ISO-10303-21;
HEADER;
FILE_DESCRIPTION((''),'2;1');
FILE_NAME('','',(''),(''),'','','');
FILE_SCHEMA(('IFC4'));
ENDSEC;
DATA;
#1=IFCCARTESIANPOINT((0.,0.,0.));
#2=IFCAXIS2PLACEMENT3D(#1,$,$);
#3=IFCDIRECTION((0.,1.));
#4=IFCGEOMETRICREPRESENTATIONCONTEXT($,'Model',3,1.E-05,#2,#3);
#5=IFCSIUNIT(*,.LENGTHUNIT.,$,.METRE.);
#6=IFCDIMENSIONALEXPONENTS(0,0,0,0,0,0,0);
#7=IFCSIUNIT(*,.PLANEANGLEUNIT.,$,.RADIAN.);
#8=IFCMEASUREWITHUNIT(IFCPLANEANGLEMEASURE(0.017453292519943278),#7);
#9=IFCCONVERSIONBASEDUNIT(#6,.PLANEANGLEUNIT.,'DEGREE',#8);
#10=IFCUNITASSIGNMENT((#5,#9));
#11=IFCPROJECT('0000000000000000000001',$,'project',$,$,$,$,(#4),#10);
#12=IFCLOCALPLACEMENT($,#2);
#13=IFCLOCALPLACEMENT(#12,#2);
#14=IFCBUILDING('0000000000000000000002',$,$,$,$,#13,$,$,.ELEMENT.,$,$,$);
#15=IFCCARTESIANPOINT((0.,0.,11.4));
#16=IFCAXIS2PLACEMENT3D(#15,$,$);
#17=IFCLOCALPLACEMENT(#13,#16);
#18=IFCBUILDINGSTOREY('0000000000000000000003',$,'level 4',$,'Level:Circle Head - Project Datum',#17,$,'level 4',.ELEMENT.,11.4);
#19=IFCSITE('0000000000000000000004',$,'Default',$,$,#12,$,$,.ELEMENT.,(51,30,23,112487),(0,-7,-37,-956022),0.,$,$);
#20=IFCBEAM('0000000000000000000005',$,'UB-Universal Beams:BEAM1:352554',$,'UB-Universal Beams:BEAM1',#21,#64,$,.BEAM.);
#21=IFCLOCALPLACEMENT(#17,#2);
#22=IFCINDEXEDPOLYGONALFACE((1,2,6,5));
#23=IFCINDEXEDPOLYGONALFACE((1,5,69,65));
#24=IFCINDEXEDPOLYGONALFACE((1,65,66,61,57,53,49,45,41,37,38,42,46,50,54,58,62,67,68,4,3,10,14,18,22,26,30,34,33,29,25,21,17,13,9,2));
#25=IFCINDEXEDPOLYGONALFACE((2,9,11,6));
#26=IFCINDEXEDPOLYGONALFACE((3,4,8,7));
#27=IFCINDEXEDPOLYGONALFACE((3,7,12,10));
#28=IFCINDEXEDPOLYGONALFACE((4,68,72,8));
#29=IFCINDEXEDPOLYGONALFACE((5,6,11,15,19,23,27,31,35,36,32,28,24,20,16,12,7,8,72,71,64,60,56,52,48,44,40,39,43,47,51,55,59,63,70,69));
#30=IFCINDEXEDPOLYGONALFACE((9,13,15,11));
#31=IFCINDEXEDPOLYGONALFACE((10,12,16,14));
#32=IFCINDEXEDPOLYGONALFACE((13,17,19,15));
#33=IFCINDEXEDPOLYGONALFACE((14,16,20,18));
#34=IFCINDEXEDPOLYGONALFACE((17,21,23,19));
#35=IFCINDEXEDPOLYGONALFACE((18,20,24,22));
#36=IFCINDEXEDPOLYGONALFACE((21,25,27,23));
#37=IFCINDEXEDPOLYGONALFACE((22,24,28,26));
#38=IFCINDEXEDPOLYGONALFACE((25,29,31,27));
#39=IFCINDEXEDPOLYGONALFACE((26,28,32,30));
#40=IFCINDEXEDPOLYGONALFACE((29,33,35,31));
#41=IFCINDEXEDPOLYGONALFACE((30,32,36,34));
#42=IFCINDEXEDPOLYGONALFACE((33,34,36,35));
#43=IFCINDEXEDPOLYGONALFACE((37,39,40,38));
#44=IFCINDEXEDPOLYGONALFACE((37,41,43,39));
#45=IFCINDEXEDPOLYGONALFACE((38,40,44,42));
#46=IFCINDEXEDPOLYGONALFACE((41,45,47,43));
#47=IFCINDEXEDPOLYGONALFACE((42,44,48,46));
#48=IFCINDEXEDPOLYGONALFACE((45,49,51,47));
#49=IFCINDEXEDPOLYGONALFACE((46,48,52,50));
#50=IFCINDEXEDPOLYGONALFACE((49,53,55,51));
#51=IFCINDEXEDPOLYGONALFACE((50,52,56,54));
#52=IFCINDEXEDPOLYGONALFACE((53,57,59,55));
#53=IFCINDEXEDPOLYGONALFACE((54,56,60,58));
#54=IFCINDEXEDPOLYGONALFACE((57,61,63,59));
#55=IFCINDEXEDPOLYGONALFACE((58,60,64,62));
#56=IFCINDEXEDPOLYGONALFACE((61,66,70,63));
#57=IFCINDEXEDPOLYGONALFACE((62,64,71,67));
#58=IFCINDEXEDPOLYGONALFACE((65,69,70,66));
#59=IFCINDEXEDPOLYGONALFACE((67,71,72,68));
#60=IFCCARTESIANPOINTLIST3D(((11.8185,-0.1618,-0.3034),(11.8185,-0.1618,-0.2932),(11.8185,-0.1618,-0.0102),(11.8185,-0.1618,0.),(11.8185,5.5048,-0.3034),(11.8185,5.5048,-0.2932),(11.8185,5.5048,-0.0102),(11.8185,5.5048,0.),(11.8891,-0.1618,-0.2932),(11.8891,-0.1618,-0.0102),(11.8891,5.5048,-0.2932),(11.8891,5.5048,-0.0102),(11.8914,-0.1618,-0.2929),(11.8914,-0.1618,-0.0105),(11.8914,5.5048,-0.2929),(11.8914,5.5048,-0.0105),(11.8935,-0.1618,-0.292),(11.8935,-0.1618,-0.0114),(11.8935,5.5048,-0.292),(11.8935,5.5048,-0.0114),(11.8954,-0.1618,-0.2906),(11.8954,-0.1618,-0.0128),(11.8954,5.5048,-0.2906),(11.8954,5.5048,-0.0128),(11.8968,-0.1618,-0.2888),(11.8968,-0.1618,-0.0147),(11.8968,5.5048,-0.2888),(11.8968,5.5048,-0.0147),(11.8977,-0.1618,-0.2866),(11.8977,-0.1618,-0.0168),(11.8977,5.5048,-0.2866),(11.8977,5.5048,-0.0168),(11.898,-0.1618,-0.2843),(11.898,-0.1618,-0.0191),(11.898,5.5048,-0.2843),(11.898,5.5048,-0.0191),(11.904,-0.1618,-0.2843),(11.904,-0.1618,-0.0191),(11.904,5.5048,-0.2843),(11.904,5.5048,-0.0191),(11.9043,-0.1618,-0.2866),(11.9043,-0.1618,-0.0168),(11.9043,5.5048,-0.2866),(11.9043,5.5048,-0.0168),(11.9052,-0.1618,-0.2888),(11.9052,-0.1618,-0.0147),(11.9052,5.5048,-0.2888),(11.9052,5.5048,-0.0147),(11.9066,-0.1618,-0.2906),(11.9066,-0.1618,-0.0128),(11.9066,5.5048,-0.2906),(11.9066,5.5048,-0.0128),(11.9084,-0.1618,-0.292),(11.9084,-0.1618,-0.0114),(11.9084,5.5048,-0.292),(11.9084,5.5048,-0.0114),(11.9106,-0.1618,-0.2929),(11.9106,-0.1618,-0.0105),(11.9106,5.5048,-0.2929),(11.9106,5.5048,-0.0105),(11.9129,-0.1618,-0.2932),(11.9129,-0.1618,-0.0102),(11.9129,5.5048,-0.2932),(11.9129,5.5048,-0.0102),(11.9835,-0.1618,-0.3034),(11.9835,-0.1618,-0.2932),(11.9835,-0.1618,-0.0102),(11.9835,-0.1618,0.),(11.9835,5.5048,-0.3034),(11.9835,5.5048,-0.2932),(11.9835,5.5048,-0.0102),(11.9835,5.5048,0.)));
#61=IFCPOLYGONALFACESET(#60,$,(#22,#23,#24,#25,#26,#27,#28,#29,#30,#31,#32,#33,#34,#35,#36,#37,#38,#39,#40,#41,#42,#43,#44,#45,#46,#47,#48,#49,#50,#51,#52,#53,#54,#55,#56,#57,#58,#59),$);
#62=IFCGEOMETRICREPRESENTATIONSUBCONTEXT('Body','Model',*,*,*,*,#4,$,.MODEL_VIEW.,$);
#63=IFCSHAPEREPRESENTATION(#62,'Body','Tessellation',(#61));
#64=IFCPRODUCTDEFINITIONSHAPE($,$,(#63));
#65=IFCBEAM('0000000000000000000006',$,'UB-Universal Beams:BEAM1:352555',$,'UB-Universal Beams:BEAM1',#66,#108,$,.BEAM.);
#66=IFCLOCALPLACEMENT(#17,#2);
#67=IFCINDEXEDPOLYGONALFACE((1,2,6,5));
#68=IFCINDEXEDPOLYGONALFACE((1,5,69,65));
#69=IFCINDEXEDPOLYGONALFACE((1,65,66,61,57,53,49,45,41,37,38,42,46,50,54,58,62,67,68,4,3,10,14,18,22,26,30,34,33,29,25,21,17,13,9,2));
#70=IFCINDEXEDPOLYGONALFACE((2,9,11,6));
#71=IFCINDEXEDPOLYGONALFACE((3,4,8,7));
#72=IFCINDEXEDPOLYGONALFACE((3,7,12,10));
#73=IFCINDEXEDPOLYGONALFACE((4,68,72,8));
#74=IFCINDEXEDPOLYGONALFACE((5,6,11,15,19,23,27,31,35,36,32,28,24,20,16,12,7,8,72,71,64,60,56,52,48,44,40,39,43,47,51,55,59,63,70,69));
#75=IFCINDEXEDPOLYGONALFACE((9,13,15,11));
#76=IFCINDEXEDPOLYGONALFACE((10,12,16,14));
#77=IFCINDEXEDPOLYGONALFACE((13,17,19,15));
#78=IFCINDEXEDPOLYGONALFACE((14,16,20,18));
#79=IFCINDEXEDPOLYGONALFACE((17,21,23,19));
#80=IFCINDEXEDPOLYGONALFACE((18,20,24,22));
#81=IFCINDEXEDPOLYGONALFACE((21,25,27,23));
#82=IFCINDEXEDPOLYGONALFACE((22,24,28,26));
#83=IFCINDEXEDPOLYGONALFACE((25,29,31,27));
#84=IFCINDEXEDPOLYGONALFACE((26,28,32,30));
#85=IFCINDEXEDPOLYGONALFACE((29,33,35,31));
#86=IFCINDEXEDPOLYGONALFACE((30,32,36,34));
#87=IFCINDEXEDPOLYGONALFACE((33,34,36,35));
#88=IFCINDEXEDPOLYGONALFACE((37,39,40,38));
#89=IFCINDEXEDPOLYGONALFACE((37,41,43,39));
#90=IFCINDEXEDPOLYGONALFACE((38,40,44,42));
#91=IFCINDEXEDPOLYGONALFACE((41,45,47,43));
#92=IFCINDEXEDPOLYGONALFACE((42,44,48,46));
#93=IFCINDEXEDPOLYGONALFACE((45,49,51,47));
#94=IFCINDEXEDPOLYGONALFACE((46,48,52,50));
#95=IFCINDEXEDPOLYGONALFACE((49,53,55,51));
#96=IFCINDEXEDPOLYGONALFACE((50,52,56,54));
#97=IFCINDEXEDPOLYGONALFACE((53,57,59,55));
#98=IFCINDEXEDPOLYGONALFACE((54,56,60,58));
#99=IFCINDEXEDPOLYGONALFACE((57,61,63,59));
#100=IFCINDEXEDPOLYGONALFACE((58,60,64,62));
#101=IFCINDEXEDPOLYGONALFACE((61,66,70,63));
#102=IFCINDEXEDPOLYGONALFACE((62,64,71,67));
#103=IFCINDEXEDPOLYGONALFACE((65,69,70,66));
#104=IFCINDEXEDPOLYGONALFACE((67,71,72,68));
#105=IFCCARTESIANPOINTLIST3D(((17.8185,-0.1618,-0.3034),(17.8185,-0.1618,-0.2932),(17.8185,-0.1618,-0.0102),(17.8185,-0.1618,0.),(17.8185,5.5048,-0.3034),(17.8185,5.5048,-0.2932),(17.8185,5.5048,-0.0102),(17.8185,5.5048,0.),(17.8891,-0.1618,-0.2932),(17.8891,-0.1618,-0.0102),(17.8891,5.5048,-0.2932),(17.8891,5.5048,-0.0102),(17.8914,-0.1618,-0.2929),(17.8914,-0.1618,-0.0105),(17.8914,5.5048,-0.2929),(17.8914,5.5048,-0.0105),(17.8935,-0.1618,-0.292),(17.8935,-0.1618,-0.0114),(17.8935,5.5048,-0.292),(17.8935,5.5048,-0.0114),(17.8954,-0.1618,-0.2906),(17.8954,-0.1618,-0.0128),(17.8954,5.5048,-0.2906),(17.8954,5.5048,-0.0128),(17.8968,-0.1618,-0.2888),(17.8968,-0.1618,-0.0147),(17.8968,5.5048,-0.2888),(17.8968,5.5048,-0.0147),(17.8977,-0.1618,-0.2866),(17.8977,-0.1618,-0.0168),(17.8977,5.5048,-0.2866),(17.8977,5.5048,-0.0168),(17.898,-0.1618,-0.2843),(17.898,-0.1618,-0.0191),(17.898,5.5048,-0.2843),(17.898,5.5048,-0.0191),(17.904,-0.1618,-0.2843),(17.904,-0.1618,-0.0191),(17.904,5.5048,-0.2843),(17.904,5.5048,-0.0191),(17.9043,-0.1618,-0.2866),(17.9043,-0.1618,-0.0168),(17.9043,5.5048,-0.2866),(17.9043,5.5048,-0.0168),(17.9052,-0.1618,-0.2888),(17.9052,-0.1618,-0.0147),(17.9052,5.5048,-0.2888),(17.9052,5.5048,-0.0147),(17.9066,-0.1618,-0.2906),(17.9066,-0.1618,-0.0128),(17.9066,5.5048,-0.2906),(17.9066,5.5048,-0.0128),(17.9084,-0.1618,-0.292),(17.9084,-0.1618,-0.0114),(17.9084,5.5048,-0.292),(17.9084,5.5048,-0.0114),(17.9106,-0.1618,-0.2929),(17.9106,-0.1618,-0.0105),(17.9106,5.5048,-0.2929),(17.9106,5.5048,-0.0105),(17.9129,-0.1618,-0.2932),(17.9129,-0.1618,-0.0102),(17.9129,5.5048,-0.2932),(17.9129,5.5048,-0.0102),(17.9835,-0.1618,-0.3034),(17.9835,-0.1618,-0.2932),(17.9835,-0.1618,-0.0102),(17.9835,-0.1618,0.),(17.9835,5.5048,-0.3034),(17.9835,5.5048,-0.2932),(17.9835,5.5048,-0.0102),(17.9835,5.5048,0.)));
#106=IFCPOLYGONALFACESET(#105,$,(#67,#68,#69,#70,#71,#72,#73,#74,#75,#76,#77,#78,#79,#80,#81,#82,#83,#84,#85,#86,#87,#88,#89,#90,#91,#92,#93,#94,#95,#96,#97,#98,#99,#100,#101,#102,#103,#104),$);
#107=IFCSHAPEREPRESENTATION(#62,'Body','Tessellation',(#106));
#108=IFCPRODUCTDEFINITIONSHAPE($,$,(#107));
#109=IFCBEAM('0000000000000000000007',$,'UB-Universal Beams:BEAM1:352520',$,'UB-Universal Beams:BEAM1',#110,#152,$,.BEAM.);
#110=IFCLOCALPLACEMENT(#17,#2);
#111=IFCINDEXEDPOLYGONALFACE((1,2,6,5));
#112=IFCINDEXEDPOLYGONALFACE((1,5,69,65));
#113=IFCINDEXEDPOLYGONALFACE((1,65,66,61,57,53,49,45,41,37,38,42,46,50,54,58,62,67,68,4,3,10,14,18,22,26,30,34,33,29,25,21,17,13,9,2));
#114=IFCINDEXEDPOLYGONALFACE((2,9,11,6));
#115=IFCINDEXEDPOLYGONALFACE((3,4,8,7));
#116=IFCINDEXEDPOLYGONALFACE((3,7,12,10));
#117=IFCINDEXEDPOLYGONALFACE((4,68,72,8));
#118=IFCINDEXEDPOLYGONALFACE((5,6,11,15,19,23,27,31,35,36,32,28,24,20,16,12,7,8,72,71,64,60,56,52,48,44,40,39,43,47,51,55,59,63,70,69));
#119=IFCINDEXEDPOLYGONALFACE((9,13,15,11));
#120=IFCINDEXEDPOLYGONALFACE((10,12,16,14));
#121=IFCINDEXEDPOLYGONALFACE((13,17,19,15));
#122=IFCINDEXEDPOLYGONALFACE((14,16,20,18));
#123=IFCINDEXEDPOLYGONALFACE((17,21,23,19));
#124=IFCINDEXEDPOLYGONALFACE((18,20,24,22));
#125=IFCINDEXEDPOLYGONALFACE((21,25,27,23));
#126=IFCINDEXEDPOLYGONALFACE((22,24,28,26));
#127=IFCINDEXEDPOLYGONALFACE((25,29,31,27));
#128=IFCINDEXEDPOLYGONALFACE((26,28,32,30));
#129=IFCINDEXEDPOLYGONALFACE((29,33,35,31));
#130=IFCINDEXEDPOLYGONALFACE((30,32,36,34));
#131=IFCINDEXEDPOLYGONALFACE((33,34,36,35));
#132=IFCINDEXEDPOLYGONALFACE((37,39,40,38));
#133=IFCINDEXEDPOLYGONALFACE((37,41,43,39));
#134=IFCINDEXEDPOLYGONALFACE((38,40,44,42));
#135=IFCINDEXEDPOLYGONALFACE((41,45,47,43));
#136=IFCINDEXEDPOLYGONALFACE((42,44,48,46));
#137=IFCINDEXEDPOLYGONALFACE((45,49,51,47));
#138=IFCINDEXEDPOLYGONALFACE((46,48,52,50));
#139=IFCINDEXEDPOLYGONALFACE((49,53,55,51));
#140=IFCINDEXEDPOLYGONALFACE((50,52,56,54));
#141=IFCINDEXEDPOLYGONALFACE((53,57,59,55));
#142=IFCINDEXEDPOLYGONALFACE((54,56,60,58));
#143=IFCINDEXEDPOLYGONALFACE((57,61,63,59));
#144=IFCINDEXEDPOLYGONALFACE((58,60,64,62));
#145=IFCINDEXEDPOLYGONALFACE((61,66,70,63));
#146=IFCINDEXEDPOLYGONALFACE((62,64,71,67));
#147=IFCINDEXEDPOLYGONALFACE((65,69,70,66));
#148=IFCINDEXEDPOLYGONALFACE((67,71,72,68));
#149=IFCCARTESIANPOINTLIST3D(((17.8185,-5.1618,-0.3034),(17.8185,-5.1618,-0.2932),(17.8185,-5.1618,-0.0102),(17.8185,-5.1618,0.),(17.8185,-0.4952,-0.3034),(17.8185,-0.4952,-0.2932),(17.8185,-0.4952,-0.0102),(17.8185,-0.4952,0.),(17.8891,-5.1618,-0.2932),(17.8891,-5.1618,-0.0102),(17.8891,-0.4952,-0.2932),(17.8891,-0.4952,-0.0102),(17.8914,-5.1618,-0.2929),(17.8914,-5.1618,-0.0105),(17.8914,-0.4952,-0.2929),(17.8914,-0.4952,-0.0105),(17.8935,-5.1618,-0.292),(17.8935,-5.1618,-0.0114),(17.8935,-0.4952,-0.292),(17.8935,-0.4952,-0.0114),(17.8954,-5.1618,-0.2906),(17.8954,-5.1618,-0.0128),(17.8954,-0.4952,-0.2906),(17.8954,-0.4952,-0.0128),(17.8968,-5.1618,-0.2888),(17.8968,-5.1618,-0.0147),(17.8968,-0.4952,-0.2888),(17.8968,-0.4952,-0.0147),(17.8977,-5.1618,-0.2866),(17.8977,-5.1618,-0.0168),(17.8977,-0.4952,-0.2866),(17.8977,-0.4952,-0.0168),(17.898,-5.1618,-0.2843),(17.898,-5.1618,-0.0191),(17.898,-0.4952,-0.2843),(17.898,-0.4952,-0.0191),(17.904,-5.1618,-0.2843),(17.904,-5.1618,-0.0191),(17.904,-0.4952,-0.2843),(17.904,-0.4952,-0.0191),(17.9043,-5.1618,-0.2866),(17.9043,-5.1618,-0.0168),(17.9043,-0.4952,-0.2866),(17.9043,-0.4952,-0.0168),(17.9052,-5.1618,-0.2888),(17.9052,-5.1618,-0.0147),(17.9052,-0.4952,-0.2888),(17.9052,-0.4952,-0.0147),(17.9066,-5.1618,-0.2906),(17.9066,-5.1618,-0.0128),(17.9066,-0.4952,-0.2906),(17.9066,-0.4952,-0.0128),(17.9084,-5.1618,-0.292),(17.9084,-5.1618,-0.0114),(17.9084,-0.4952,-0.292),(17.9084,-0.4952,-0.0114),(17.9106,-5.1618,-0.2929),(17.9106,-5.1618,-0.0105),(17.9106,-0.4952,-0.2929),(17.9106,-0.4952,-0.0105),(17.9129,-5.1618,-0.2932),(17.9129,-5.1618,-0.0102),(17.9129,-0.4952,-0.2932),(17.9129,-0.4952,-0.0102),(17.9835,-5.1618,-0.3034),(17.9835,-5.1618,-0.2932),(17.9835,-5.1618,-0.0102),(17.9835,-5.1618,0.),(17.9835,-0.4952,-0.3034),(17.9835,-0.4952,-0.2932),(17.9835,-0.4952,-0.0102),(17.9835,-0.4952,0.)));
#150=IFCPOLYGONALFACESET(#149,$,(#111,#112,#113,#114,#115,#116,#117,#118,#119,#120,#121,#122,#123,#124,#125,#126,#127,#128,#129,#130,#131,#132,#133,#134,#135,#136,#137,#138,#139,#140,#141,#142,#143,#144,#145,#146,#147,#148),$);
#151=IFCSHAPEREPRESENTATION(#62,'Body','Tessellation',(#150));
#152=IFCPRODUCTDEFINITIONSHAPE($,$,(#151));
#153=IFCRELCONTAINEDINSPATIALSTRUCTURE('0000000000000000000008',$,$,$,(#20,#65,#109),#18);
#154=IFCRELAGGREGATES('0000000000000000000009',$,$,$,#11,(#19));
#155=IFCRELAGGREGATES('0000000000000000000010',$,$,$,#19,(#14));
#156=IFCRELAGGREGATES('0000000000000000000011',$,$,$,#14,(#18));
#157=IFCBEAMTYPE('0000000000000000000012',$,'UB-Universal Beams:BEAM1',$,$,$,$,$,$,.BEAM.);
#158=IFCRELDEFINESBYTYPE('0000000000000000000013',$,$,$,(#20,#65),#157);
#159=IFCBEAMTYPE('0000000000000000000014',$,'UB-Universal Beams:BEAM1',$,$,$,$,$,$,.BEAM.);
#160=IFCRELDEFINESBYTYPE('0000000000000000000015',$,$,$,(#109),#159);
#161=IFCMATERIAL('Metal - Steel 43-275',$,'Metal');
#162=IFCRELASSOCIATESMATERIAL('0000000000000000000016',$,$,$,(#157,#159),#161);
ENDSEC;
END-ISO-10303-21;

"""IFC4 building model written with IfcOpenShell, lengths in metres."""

from ifc_helpers import new_model, entity, si_unit, converted_unit, direction, frame, frame_2d, origin, place, context, subcontext, project, spatial, polyline, circle_curve, parameter, trimmed, segment, composite_curve, outline, extrude, source, transform, mapped, material, material_profile, profile_set, type_object, type_shapes, element, save


model = new_model("IFC4")

# Units and contexts
model_context = context("Model", 3, precision=1e-05, world=origin(), true_north=direction((0.0, 1.0)))
body_context = subcontext(model_context, "Body", "Model", "MODEL_VIEW")
ifc_project = project(units=[si_unit("LENGTHUNIT", "METRE"), converted_unit("PLANEANGLEUNIT", "DEGREE", entity("IfcPlaneAngleMeasure", 0.017453292519943278), si_unit("PLANEANGLEUNIT", "RADIAN"), dimensions=[0, 0, 0, 0, 0, 0, 0])], contexts=[model_context])

# Site, building, storey
site_placement = place(None, origin())
site = spatial("IfcSite", under=ifc_project, at=site_placement, Name="Default", CompositionType="ELEMENT", RefLatitude=(51, 30, 23, 112487), RefLongitude=(0, -7, -37, -956022), RefElevation=0.0)
building_placement = place(site_placement, origin())
building = spatial("IfcBuilding", under=site, at=building_placement, CompositionType="ELEMENT")
storey_placement = place(building_placement, frame((0.0, 0.0, 11.4)))
storey = spatial("IfcBuildingStorey", under=building, at=storey_placement, Name="level 4", ObjectType="Level:Circle Head - Project Datum", LongName="level 4", CompositionType="ELEMENT", Elevation=11.4)

# Shared definitions
ifc_material_1 = material(Name="Metal - Steel 43-275", Category="Metal")

# Beams
ifc_material_profile_1 = material_profile(ifc_material_1, outline(composite_curve([segment(polyline([(-0.0825, -0.1415), (-0.0825, -0.1517)]), True, "CONTINUOUS"), segment(polyline([(-0.0825, -0.1517), (0.0825, -0.1517)]), True, "CONTINUOUS"), segment(polyline([(0.0825, -0.1517), (0.0825, -0.1415)]), True, "CONTINUOUS"), segment(polyline([(0.0825, -0.1415), (0.0119, -0.1415)]), True, "CONTINUOUS"), segment(trimmed(circle_curve(frame_2d((0.0119, -0.1326), x_axis=(1.0, 0.0)), 0.0089), [parameter(180.0)], [parameter(270.0)], True, "PARAMETER"), False, "CONTINUOUS"), segment(polyline([(0.003, -0.1326), (0.003, 0.1326)]), True, "CONTINUOUS"), segment(trimmed(circle_curve(frame_2d((0.0119, 0.1326), x_axis=(1.0, 0.0)), 0.0089), [parameter(90.0)], [parameter(180.0)], True, "PARAMETER"), False, "CONTINUOUS"), segment(polyline([(0.0119, 0.1415), (0.0825, 0.1415)]), True, "CONTINUOUS"), segment(polyline([(0.0825, 0.1415), (0.0825, 0.1517)]), True, "CONTINUOUS"), segment(polyline([(0.0825, 0.1517), (-0.0825, 0.1517)]), True, "CONTINUOUS"), segment(polyline([(-0.0825, 0.1517), (-0.0825, 0.1415)]), True, "CONTINUOUS"), segment(polyline([(-0.0825, 0.1415), (-0.0119, 0.1415)]), True, "CONTINUOUS"), segment(trimmed(circle_curve(frame_2d((-0.0119, 0.1326), x_axis=(1.0, 0.0)), 0.0089), [parameter(360.0)], [parameter(90.0)], True, "PARAMETER"), False, "CONTINUOUS"), segment(polyline([(-0.003, 0.1326), (-0.003, -0.1326)]), True, "CONTINUOUS"), segment(trimmed(circle_curve(frame_2d((-0.0119, -0.1326), x_axis=(1.0, 0.0)), 0.0089), [parameter(270.0)], [parameter(360.0)], True, "PARAMETER"), False, "CONTINUOUS"), segment(polyline([(-0.0119, -0.1415), (-0.0825, -0.1415)]), True, "CONTINUOUS")], self_intersect=False)), Name="BEAM1")
ifc_profile_set_1 = profile_set([ifc_material_profile_1], Name="BEAM1")
beam_type_1 = type_object("IfcBeamType", Name="UB-Universal Beams:BEAM1", PredefinedType="BEAM", material=ifc_profile_set_1)
shared_shape_1 = source(origin(), body_context, "Body", "SweptSolid", [
    extrude(outline(composite_curve([segment(polyline([(-0.0825, -0.1415), (-0.0825, -0.1517)]), True, "CONTINUOUS"), segment(polyline([(-0.0825, -0.1517), (0.0825, -0.1517)]), True, "CONTINUOUS"), segment(polyline([(0.0825, -0.1517), (0.0825, -0.1415)]), True, "CONTINUOUS"), segment(polyline([(0.0825, -0.1415), (0.0119, -0.1415)]), True, "CONTINUOUS"), segment(trimmed(circle_curve(frame_2d((0.0119, -0.1326), x_axis=(1.0, 0.0)), 0.0089), [parameter(180.0)], [parameter(270.0)], True, "PARAMETER"), False, "CONTINUOUS"), segment(polyline([(0.003, -0.1326), (0.003, 0.1326)]), True, "CONTINUOUS"), segment(trimmed(circle_curve(frame_2d((0.0119, 0.1326), x_axis=(1.0, 0.0)), 0.0089), [parameter(90.0)], [parameter(180.0)], True, "PARAMETER"), False, "CONTINUOUS"), segment(polyline([(0.0119, 0.1415), (0.0825, 0.1415)]), True, "CONTINUOUS"), segment(polyline([(0.0825, 0.1415), (0.0825, 0.1517)]), True, "CONTINUOUS"), segment(polyline([(0.0825, 0.1517), (-0.0825, 0.1517)]), True, "CONTINUOUS"), segment(polyline([(-0.0825, 0.1517), (-0.0825, 0.1415)]), True, "CONTINUOUS"), segment(polyline([(-0.0825, 0.1415), (-0.0119, 0.1415)]), True, "CONTINUOUS"), segment(trimmed(circle_curve(frame_2d((-0.0119, 0.1326), x_axis=(1.0, 0.0)), 0.0089), [parameter(360.0)], [parameter(90.0)], True, "PARAMETER"), False, "CONTINUOUS"), segment(polyline([(-0.003, 0.1326), (-0.003, -0.1326)]), True, "CONTINUOUS"), segment(trimmed(circle_curve(frame_2d((-0.0119, -0.1326), x_axis=(1.0, 0.0)), 0.0089), [parameter(270.0)], [parameter(360.0)], True, "PARAMETER"), False, "CONTINUOUS"), segment(polyline([(-0.0119, -0.1415), (-0.0825, -0.1415)]), True, "CONTINUOUS")], self_intersect=False)), frame((-2.8333, 0.0, 0.0), z_axis=(-1.0, 0.0, 0.0), x_axis=(0.0, -1.0, 0.0)), (0.0, 0.0, -1.0), 5.6666),
])
type_shapes(beam_type_1, [shared_shape_1])
for number, where, z_axis, x_axis, name in (
    (1, (11.901, 2.6715, -0.1517), (0.0, 0.0, 1.0), (0.0, -1.0, 0.0), "UB-Universal Beams:BEAM1:352554"),
    (2, (17.901, 2.6715, -0.1517), (0.0, 0.0, 1.0), (0.0, -1.0, 0.0), "UB-Universal Beams:BEAM1:352555"),
):
    element("IfcBeam", number, at=place(storey_placement, frame(where, z_axis=z_axis, x_axis=x_axis)), inside=storey, type_object=beam_type_1, Name=name, ObjectType="UB-Universal Beams:BEAM1", PredefinedType="BEAM", context=body_context, shape_type="MappedRepresentation", body=[
        mapped(shared_shape_1, transform((0.0, 0.0, 0.0), scale=1.0)),
    ])
beam_type_2 = type_object("IfcBeamType", Name="UB-Universal Beams:BEAM1", PredefinedType="BEAM", material=ifc_profile_set_1)
shared_shape_2 = source(origin(), body_context, "Body", "SweptSolid", [
    extrude(outline(composite_curve([segment(polyline([(-0.0825, -0.1415), (-0.0825, -0.1517)]), True, "CONTINUOUS"), segment(polyline([(-0.0825, -0.1517), (0.0825, -0.1517)]), True, "CONTINUOUS"), segment(polyline([(0.0825, -0.1517), (0.0825, -0.1415)]), True, "CONTINUOUS"), segment(polyline([(0.0825, -0.1415), (0.0119, -0.1415)]), True, "CONTINUOUS"), segment(trimmed(circle_curve(frame_2d((0.0119, -0.1326), x_axis=(0.0, -1.0)), 0.0089), [parameter(270.0)], [parameter(360.0)], True, "PARAMETER"), False, "CONTINUOUS"), segment(polyline([(0.003, -0.1326), (0.003, 0.1326)]), True, "CONTINUOUS"), segment(trimmed(circle_curve(frame_2d((0.0119, 0.1326), x_axis=(-1.0, 0.0)), 0.0089), [parameter(270.0)], [parameter(360.0)], True, "PARAMETER"), False, "CONTINUOUS"), segment(polyline([(0.0119, 0.1415), (0.0825, 0.1415)]), True, "CONTINUOUS"), segment(polyline([(0.0825, 0.1415), (0.0825, 0.1517)]), True, "CONTINUOUS"), segment(polyline([(0.0825, 0.1517), (-0.0825, 0.1517)]), True, "CONTINUOUS"), segment(polyline([(-0.0825, 0.1517), (-0.0825, 0.1415)]), True, "CONTINUOUS"), segment(polyline([(-0.0825, 0.1415), (-0.0119, 0.1415)]), True, "CONTINUOUS"), segment(trimmed(circle_curve(frame_2d((-0.0119, 0.1326), x_axis=(0.0, 1.0)), 0.0089), [parameter(270.0)], [parameter(360.0)], True, "PARAMETER"), False, "CONTINUOUS"), segment(polyline([(-0.003, 0.1326), (-0.003, -0.1326)]), True, "CONTINUOUS"), segment(trimmed(circle_curve(frame_2d((-0.0119, -0.1326), x_axis=(1.0, 0.0)), 0.0089), [parameter(270.0)], [parameter(0.0)], True, "PARAMETER"), False, "CONTINUOUS"), segment(polyline([(-0.0119, -0.1415), (-0.0825, -0.1415)]), True, "CONTINUOUS")], self_intersect=False)), frame((-2.3333, 0.0, 0.0), z_axis=(-1.0, 0.0, 0.0), x_axis=(0.0, -1.0, 0.0)), (0.0, 0.0, -1.0), 4.6666),
])
type_shapes(beam_type_2, [shared_shape_2])
beam_placement = place(storey_placement, frame((17.901, -2.8285, -0.1517), z_axis=(0.0, 0.0, 1.0), x_axis=(0.0, -1.0, 0.0)))
element("IfcBeam", 3, at=beam_placement, inside=storey, type_object=beam_type_2, Name="UB-Universal Beams:BEAM1:352520", ObjectType="UB-Universal Beams:BEAM1", PredefinedType="BEAM", context=body_context, shape_type="MappedRepresentation", body=[
    mapped(shared_shape_2, transform((0.0, 0.0, 0.0), scale=1.0)),
])

save(model, "model.ifc")
